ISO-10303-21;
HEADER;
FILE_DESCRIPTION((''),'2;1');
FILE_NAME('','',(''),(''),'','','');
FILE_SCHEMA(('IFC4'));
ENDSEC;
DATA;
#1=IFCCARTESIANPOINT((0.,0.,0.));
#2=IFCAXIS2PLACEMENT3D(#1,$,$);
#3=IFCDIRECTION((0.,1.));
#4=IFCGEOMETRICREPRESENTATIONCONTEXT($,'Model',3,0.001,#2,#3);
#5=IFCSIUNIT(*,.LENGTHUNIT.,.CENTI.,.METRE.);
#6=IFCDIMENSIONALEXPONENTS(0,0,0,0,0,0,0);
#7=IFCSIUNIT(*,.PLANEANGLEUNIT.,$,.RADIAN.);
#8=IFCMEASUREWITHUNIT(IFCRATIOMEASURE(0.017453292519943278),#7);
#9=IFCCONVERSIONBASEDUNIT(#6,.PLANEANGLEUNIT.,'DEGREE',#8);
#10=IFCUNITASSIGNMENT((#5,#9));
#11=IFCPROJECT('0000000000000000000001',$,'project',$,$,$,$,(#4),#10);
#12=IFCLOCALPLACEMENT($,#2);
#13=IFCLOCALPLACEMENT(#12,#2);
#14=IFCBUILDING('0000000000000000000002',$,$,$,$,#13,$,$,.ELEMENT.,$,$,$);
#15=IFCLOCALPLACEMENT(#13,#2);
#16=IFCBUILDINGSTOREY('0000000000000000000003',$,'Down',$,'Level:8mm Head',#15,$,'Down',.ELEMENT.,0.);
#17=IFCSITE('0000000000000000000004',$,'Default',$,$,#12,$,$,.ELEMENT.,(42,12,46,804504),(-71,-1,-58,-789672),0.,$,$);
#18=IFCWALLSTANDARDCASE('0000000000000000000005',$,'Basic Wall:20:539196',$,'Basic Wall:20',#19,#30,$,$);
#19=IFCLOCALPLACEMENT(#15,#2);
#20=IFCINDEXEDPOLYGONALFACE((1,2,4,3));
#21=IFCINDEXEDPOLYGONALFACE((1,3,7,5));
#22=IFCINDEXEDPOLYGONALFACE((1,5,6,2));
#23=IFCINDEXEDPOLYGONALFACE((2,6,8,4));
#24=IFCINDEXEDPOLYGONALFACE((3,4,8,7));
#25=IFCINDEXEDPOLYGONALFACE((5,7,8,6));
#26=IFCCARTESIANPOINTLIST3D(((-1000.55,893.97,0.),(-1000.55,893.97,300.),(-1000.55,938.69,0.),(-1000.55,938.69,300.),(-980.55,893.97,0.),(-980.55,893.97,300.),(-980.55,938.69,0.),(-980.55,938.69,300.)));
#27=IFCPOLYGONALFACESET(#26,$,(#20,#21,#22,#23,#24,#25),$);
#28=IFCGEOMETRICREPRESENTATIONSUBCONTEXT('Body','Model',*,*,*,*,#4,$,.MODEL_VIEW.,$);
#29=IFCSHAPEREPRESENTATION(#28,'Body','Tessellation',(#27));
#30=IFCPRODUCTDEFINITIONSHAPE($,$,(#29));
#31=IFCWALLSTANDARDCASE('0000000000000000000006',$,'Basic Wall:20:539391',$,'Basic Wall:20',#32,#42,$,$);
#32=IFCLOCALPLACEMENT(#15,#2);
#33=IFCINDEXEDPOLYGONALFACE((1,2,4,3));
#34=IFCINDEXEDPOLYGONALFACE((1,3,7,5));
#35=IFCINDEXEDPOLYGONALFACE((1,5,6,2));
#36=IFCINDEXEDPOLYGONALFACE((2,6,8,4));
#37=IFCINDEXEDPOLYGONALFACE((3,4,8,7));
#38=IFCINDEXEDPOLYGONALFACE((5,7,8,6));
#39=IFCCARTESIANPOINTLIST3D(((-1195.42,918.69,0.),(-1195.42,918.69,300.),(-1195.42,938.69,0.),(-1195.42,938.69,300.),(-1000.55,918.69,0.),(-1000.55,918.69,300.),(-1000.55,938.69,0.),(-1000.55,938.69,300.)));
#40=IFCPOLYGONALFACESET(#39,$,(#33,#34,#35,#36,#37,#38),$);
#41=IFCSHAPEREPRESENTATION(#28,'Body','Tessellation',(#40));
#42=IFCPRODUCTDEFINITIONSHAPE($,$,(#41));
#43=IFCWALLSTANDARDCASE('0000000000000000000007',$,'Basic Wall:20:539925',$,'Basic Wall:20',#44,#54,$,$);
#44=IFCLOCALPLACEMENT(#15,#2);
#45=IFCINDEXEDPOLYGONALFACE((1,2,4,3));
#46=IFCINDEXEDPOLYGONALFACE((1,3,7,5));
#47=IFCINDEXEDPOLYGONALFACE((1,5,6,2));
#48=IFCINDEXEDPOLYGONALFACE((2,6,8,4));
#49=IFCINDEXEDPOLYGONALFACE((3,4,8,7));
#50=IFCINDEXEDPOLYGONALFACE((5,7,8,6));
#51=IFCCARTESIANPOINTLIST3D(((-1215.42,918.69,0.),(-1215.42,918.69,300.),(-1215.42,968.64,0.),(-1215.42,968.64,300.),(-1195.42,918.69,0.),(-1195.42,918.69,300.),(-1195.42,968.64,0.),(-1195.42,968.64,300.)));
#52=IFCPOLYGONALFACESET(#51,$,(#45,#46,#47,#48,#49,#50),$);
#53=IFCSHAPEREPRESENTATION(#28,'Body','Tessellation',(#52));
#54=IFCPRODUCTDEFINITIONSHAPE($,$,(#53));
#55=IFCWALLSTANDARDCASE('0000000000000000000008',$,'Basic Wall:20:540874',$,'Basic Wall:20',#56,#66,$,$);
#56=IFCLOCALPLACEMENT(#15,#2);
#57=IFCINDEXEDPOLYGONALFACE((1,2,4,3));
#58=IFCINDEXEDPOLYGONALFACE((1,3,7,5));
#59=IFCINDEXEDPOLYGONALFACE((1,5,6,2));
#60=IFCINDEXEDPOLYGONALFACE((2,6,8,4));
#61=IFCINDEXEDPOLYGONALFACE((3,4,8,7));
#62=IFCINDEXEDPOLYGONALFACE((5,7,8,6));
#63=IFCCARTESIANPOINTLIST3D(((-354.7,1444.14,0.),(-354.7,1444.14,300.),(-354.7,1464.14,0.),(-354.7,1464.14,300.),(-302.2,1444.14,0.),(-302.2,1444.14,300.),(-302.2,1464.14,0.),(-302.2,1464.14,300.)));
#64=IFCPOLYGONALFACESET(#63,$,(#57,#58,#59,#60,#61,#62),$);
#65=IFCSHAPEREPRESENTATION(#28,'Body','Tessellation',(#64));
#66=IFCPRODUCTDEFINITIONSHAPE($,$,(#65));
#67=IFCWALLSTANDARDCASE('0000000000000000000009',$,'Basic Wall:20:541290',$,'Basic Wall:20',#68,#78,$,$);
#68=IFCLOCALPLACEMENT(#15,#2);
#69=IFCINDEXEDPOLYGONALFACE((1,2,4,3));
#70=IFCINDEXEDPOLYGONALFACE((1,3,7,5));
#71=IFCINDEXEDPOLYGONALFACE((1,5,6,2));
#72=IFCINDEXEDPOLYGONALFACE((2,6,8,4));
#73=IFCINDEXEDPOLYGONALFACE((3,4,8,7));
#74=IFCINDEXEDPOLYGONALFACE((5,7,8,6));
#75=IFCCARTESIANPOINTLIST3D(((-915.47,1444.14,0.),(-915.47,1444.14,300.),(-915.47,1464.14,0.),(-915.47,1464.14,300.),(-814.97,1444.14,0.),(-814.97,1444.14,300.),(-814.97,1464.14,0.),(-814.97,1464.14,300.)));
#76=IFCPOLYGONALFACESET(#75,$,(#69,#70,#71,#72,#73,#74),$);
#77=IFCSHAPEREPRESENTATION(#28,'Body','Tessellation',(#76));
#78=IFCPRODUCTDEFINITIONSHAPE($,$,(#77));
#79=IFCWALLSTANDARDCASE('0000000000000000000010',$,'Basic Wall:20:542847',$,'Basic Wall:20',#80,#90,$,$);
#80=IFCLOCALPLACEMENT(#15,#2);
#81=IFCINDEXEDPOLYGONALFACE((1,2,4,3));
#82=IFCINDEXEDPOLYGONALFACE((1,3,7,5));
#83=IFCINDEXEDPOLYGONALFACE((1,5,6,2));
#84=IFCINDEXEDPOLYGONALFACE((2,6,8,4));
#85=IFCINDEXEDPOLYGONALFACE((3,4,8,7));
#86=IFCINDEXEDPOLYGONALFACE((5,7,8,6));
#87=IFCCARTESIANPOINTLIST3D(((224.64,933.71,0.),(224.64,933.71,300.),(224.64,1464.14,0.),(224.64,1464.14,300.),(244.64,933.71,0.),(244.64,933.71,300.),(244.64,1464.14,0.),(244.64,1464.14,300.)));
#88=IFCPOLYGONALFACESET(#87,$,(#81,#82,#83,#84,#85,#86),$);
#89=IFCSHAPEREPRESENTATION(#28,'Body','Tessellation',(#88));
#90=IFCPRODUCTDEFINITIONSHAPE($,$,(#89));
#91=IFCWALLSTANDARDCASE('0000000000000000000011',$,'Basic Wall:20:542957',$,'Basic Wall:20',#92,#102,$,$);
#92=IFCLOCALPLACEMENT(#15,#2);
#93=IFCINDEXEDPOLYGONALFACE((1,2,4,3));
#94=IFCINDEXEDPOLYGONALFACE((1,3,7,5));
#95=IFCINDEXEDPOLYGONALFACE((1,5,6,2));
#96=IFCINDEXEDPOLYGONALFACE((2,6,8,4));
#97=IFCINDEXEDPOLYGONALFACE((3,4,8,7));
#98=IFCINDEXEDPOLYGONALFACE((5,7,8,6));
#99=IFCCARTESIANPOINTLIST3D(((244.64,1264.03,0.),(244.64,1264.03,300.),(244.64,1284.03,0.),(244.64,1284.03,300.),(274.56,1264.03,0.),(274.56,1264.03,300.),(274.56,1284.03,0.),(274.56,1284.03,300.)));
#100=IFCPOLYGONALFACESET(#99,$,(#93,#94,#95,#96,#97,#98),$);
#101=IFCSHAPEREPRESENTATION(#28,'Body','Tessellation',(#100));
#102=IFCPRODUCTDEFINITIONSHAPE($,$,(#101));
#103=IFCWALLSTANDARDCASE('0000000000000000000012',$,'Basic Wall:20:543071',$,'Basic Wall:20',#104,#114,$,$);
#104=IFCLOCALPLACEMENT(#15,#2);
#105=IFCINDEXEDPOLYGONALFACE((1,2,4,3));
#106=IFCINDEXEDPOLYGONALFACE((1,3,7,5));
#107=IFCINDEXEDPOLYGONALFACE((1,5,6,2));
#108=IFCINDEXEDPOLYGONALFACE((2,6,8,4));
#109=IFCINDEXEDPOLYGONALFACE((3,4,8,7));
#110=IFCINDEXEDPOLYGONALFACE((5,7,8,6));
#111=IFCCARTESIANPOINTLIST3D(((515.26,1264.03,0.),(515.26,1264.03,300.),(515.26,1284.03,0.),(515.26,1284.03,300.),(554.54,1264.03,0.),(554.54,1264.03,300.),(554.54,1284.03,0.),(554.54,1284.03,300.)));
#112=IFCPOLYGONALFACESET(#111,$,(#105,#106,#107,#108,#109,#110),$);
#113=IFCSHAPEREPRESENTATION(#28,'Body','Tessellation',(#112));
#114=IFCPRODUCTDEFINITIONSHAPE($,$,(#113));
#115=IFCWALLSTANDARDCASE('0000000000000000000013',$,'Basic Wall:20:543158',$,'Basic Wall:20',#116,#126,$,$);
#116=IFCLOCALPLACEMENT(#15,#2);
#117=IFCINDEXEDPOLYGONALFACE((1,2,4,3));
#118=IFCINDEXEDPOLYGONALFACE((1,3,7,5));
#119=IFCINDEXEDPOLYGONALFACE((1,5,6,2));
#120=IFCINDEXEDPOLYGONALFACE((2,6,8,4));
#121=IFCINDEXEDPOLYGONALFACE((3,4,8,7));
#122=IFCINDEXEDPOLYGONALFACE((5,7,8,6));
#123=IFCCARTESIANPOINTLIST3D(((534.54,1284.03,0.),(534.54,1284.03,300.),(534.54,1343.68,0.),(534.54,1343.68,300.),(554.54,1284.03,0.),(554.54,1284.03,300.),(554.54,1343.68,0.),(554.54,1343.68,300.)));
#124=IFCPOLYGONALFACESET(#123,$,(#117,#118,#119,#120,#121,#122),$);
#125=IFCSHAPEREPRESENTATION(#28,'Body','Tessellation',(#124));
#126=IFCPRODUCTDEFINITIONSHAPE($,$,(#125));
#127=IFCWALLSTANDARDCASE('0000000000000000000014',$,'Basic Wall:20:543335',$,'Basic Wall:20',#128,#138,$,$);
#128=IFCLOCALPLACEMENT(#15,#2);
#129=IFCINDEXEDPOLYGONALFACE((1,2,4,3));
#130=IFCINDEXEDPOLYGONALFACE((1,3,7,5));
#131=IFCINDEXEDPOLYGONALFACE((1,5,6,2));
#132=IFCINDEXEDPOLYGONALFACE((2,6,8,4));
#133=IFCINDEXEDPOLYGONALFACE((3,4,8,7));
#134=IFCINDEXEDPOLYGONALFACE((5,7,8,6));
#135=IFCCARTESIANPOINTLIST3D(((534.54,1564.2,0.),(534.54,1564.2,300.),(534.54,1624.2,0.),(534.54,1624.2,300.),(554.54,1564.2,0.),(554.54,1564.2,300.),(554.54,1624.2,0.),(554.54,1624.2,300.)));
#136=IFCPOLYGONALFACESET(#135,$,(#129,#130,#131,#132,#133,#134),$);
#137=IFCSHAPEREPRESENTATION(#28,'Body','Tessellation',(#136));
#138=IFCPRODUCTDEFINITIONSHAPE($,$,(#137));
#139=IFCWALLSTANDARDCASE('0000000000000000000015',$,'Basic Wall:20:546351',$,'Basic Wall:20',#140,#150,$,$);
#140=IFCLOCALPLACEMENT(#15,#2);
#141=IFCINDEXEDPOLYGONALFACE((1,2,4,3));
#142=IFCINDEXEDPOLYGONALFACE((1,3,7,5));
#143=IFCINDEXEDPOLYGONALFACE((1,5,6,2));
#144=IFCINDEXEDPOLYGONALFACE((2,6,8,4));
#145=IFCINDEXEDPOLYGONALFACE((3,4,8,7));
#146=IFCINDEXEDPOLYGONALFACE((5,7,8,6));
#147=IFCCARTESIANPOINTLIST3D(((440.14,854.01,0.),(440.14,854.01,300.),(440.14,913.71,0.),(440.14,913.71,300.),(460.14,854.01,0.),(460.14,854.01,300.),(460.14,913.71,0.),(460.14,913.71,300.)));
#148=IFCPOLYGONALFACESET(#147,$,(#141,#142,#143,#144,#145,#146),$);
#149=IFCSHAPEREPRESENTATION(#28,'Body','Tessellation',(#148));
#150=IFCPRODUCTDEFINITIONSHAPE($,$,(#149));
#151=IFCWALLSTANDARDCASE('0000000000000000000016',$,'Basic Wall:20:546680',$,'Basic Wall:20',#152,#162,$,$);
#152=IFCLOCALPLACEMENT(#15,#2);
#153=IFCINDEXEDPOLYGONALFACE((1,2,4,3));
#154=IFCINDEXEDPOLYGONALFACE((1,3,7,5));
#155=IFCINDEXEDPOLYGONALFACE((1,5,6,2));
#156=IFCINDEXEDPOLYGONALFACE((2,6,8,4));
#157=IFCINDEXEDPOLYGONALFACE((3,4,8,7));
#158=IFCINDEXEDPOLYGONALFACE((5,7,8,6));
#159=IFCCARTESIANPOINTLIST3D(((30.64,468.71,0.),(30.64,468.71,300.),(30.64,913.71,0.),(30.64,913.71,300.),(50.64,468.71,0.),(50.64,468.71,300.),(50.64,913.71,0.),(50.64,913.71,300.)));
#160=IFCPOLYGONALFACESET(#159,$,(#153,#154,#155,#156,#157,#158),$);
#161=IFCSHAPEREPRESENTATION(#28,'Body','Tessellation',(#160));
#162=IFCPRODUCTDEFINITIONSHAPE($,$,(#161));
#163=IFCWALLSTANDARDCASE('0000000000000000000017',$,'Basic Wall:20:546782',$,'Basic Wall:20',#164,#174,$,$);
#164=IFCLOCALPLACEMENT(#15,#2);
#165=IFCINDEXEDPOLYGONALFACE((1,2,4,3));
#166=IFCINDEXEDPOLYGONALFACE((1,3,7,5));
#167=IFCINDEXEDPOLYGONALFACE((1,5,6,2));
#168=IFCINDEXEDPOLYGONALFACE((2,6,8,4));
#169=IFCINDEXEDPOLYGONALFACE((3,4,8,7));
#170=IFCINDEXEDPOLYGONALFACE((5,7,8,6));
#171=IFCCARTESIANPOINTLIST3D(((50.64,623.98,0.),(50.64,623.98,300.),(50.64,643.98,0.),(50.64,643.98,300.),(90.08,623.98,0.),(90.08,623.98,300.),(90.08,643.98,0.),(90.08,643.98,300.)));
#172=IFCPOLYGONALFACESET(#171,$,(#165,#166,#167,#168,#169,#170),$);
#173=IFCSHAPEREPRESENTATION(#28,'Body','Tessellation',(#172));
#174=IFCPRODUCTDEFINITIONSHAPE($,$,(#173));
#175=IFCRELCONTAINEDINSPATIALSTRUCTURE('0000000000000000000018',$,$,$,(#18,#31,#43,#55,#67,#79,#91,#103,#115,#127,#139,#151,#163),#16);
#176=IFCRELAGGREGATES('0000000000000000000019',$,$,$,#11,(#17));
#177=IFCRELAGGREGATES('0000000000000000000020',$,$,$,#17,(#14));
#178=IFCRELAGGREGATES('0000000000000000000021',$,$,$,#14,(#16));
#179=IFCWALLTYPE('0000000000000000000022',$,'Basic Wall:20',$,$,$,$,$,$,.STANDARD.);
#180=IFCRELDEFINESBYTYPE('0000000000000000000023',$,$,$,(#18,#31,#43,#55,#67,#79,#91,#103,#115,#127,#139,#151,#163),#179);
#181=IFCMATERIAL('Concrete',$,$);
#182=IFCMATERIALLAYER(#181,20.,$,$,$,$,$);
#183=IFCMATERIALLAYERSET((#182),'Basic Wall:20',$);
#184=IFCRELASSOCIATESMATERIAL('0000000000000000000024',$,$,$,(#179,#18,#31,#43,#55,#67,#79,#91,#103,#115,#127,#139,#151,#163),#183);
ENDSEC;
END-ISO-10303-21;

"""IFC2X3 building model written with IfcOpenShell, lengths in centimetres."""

from ifc_helpers import new_model, entity, si_unit, converted_unit, direction, frame, frame_2d, origin, place, context, subcontext, project, spatial, rectangle, extrude, material, layer, layer_set, layer_usage, type_object, element, save


model = new_model("IFC2X3")

# Units and contexts
model_context = context("Model", 3, precision=0.001, world=origin(), true_north=direction((0.0, 1.0)))
body_context = subcontext(model_context, "Body", "Model", "MODEL_VIEW")
ifc_project = project(units=[si_unit("LENGTHUNIT", "METRE", prefix="CENTI"), converted_unit("PLANEANGLEUNIT", "DEGREE", entity("IfcRatioMeasure", 0.017453292519943278), si_unit("PLANEANGLEUNIT", "RADIAN"), dimensions=[0, 0, 0, 0, 0, 0, 0])], contexts=[model_context])

# Site, building, storey
site_placement = place(None, origin())
site = spatial("IfcSite", under=ifc_project, at=site_placement, Name="Default", CompositionType="ELEMENT", RefLatitude=(42, 12, 46, 804504), RefLongitude=(-71, -1, -58, -789672), RefElevation=0.0)
building_placement = place(site_placement, origin())
building = spatial("IfcBuilding", under=site, at=building_placement, CompositionType="ELEMENT")
storey_placement = place(building_placement, origin())
storey = spatial("IfcBuildingStorey", under=building, at=storey_placement, Name="Down", ObjectType="Level:8mm Head", LongName="Down", CompositionType="ELEMENT", Elevation=0.0)

# Walls
ifc_material = material(Name="Concrete")
ifc_layer_1 = layer(ifc_material, 20.0)
ifc_layer_set_1 = layer_set([ifc_layer_1], Name="Basic Wall:20")
ifc_layer_usage_1 = layer_usage(ifc_layer_set_1, "AXIS2", "POSITIVE", -10.0)
wall_type_1 = type_object("IfcWallType", Name="Basic Wall:20", PredefinedType="STANDARD", material=ifc_layer_set_1)
wall_1_placement = place(storey_placement, frame((-990.55, 893.97, 0.0), z_axis=(0.0, 0.0, 1.0), x_axis=(0.0, 1.0, 0.0)))
element("IfcWallStandardCase", 1, at=wall_1_placement, inside=storey, type_object=wall_type_1, material=ifc_layer_usage_1, Name="Basic Wall:20:539196", ObjectType="Basic Wall:20", context=body_context, shape_type="SweptSolid", body=[
    extrude(rectangle(XDim=44.71, YDim=20.0, at=frame_2d((22.36, 0.0), x_axis=(-1.0, 0.0))), origin(), (0.0, 0.0, 1.0), 300.0),
])
ifc_layer_usage_2 = layer_usage(ifc_layer_set_1, "AXIS2", "POSITIVE", -10.0)
wall_2_placement = place(storey_placement, frame((-1000.55, 928.69, 0.0), z_axis=(0.0, 0.0, 1.0), x_axis=(-1.0, 0.0, 0.0)))
element("IfcWallStandardCase", 2, at=wall_2_placement, inside=storey, type_object=wall_type_1, material=ifc_layer_usage_2, Name="Basic Wall:20:539391", ObjectType="Basic Wall:20", context=body_context, shape_type="SweptSolid", body=[
    extrude(rectangle(XDim=194.87, YDim=20.0, at=frame_2d((97.44, 0.0), x_axis=(-1.0, 0.0))), origin(), (0.0, 0.0, 1.0), 300.0),
])
ifc_layer_usage_3 = layer_usage(ifc_layer_set_1, "AXIS2", "NEGATIVE", 10.0)
wall_3_placement = place(storey_placement, frame((-1205.42, 918.69, 0.0), z_axis=(0.0, 0.0, 1.0), x_axis=(0.0, 1.0, 0.0)))
element("IfcWallStandardCase", 3, at=wall_3_placement, inside=storey, type_object=wall_type_1, material=ifc_layer_usage_3, Name="Basic Wall:20:539925", ObjectType="Basic Wall:20", context=body_context, shape_type="SweptSolid", body=[
    extrude(rectangle(XDim=49.95, YDim=20.0, at=frame_2d((24.98, 0.0), x_axis=(-1.0, 0.0))), origin(), (0.0, 0.0, 1.0), 300.0),
])
ifc_layer_usage_4 = layer_usage(ifc_layer_set_1, "AXIS2", "POSITIVE", -10.0)
wall_4_placement = place(storey_placement, frame((-302.2, 1454.14, 0.0), z_axis=(0.0, 0.0, 1.0), x_axis=(-1.0, 0.0, 0.0)))
element("IfcWallStandardCase", 4, at=wall_4_placement, inside=storey, type_object=wall_type_1, material=ifc_layer_usage_4, Name="Basic Wall:20:540874", ObjectType="Basic Wall:20", context=body_context, shape_type="SweptSolid", body=[
    extrude(rectangle(XDim=52.5, YDim=20.0, at=frame_2d((26.25, 0.0), x_axis=(-1.0, 0.0))), origin(), (0.0, 0.0, 1.0), 300.0),
])
ifc_layer_usage_5 = layer_usage(ifc_layer_set_1, "AXIS2", "NEGATIVE", 10.0)
wall_5_placement = place(storey_placement, frame((-915.47, 1454.14, 0.0)))
element("IfcWallStandardCase", 5, at=wall_5_placement, inside=storey, type_object=wall_type_1, material=ifc_layer_usage_5, Name="Basic Wall:20:541290", ObjectType="Basic Wall:20", context=body_context, shape_type="SweptSolid", body=[
    extrude(rectangle(XDim=100.5, YDim=20.0, at=frame_2d((50.25, 0.0), x_axis=(-1.0, 0.0))), origin(), (0.0, 0.0, 1.0), 300.0),
])
ifc_layer_usage_6 = layer_usage(ifc_layer_set_1, "AXIS2", "POSITIVE", -10.0)
wall_6_placement = place(storey_placement, frame((234.64, 1464.14, 0.0), z_axis=(0.0, 0.0, 1.0), x_axis=(0.0, -1.0, 0.0)))
element("IfcWallStandardCase", 6, at=wall_6_placement, inside=storey, type_object=wall_type_1, material=ifc_layer_usage_6, Name="Basic Wall:20:542847", ObjectType="Basic Wall:20", context=body_context, shape_type="SweptSolid", body=[
    extrude(rectangle(XDim=530.43, YDim=20.0, at=frame_2d((265.22, 0.0), x_axis=(-1.0, 0.0))), origin(), (0.0, 0.0, 1.0), 300.0),
])
ifc_layer_usage_7 = layer_usage(ifc_layer_set_1, "AXIS2", "NEGATIVE", 10.0)
wall_7_placement = place(storey_placement, frame((274.56, 1274.03, 0.0), z_axis=(0.0, 0.0, 1.0), x_axis=(-1.0, 0.0, 0.0)))
element("IfcWallStandardCase", 7, at=wall_7_placement, inside=storey, type_object=wall_type_1, material=ifc_layer_usage_7, Name="Basic Wall:20:542957", ObjectType="Basic Wall:20", context=body_context, shape_type="SweptSolid", body=[
    extrude(rectangle(XDim=29.92, YDim=20.0, at=frame_2d((14.96, 0.0), x_axis=(-1.0, 0.0))), origin(), (0.0, 0.0, 1.0), 300.0),
])
ifc_layer_usage_8 = layer_usage(ifc_layer_set_1, "AXIS2", "POSITIVE", -10.0)
wall_8_placement = place(storey_placement, frame((515.26, 1274.03, 0.0)))
element("IfcWallStandardCase", 8, at=wall_8_placement, inside=storey, type_object=wall_type_1, material=ifc_layer_usage_8, Name="Basic Wall:20:543071", ObjectType="Basic Wall:20", context=body_context, shape_type="SweptSolid", body=[
    extrude(rectangle(XDim=39.28, YDim=20.0, at=frame_2d((19.64, 0.0), x_axis=(-1.0, 0.0))), origin(), (0.0, 0.0, 1.0), 300.0),
])
ifc_layer_usage_9 = layer_usage(ifc_layer_set_1, "AXIS2", "POSITIVE", -10.0)
wall_9_placement = place(storey_placement, frame((544.54, 1284.03, 0.0), z_axis=(0.0, 0.0, 1.0), x_axis=(0.0, 1.0, 0.0)))
element("IfcWallStandardCase", 9, at=wall_9_placement, inside=storey, type_object=wall_type_1, material=ifc_layer_usage_9, Name="Basic Wall:20:543158", ObjectType="Basic Wall:20", context=body_context, shape_type="SweptSolid", body=[
    extrude(rectangle(XDim=59.65, YDim=20.0, at=frame_2d((29.83, 0.0), x_axis=(-1.0, 0.0))), origin(), (0.0, 0.0, 1.0), 300.0),
])
ifc_layer_usage_10 = layer_usage(ifc_layer_set_1, "AXIS2", "NEGATIVE", 10.0)
wall_10_placement = place(storey_placement, frame((544.54, 1564.2, 0.0), z_axis=(0.0, 0.0, 1.0), x_axis=(0.0, 1.0, 0.0)))
element("IfcWallStandardCase", 10, at=wall_10_placement, inside=storey, type_object=wall_type_1, material=ifc_layer_usage_10, Name="Basic Wall:20:543335", ObjectType="Basic Wall:20", context=body_context, shape_type="SweptSolid", body=[
    extrude(rectangle(XDim=60.0, YDim=20.0, at=frame_2d((30.0, 0.0), x_axis=(-1.0, 0.0))), origin(), (0.0, 0.0, 1.0), 300.0),
])
ifc_layer_usage_11 = layer_usage(ifc_layer_set_1, "AXIS2", "NEGATIVE", 10.0)
wall_11_placement = place(storey_placement, frame((450.14, 854.01, 0.0), z_axis=(0.0, 0.0, 1.0), x_axis=(0.0, 1.0, 0.0)))
element("IfcWallStandardCase", 11, at=wall_11_placement, inside=storey, type_object=wall_type_1, material=ifc_layer_usage_11, Name="Basic Wall:20:546351", ObjectType="Basic Wall:20", context=body_context, shape_type="SweptSolid", body=[
    extrude(rectangle(XDim=59.7, YDim=20.0, at=frame_2d((29.85, 0.0), x_axis=(-1.0, 0.0))), origin(), (0.0, 0.0, 1.0), 300.0),
])
ifc_layer_usage_12 = layer_usage(ifc_layer_set_1, "AXIS2", "POSITIVE", -10.0)
wall_12_placement = place(storey_placement, frame((40.64, 913.71, 0.0), z_axis=(0.0, 0.0, 1.0), x_axis=(0.0, -1.0, 0.0)))
element("IfcWallStandardCase", 12, at=wall_12_placement, inside=storey, type_object=wall_type_1, material=ifc_layer_usage_12, Name="Basic Wall:20:546680", ObjectType="Basic Wall:20", context=body_context, shape_type="SweptSolid", body=[
    extrude(rectangle(XDim=445.0, YDim=20.0, at=frame_2d((222.5, 0.0), x_axis=(-1.0, 0.0))), origin(), (0.0, 0.0, 1.0), 300.0),
])
ifc_layer_usage_13 = layer_usage(ifc_layer_set_1, "AXIS2", "POSITIVE", -10.0)
wall_13_placement = place(storey_placement, frame((50.64, 633.98, 0.0)))
element("IfcWallStandardCase", 13, at=wall_13_placement, inside=storey, type_object=wall_type_1, material=ifc_layer_usage_13, Name="Basic Wall:20:546782", ObjectType="Basic Wall:20", context=body_context, shape_type="SweptSolid", body=[
    extrude(rectangle(XDim=39.43, YDim=20.0, at=frame_2d((19.72, 0.0), x_axis=(-1.0, 0.0))), origin(), (0.0, 0.0, 1.0), 300.0),
])

save(model, "model.ifc")
